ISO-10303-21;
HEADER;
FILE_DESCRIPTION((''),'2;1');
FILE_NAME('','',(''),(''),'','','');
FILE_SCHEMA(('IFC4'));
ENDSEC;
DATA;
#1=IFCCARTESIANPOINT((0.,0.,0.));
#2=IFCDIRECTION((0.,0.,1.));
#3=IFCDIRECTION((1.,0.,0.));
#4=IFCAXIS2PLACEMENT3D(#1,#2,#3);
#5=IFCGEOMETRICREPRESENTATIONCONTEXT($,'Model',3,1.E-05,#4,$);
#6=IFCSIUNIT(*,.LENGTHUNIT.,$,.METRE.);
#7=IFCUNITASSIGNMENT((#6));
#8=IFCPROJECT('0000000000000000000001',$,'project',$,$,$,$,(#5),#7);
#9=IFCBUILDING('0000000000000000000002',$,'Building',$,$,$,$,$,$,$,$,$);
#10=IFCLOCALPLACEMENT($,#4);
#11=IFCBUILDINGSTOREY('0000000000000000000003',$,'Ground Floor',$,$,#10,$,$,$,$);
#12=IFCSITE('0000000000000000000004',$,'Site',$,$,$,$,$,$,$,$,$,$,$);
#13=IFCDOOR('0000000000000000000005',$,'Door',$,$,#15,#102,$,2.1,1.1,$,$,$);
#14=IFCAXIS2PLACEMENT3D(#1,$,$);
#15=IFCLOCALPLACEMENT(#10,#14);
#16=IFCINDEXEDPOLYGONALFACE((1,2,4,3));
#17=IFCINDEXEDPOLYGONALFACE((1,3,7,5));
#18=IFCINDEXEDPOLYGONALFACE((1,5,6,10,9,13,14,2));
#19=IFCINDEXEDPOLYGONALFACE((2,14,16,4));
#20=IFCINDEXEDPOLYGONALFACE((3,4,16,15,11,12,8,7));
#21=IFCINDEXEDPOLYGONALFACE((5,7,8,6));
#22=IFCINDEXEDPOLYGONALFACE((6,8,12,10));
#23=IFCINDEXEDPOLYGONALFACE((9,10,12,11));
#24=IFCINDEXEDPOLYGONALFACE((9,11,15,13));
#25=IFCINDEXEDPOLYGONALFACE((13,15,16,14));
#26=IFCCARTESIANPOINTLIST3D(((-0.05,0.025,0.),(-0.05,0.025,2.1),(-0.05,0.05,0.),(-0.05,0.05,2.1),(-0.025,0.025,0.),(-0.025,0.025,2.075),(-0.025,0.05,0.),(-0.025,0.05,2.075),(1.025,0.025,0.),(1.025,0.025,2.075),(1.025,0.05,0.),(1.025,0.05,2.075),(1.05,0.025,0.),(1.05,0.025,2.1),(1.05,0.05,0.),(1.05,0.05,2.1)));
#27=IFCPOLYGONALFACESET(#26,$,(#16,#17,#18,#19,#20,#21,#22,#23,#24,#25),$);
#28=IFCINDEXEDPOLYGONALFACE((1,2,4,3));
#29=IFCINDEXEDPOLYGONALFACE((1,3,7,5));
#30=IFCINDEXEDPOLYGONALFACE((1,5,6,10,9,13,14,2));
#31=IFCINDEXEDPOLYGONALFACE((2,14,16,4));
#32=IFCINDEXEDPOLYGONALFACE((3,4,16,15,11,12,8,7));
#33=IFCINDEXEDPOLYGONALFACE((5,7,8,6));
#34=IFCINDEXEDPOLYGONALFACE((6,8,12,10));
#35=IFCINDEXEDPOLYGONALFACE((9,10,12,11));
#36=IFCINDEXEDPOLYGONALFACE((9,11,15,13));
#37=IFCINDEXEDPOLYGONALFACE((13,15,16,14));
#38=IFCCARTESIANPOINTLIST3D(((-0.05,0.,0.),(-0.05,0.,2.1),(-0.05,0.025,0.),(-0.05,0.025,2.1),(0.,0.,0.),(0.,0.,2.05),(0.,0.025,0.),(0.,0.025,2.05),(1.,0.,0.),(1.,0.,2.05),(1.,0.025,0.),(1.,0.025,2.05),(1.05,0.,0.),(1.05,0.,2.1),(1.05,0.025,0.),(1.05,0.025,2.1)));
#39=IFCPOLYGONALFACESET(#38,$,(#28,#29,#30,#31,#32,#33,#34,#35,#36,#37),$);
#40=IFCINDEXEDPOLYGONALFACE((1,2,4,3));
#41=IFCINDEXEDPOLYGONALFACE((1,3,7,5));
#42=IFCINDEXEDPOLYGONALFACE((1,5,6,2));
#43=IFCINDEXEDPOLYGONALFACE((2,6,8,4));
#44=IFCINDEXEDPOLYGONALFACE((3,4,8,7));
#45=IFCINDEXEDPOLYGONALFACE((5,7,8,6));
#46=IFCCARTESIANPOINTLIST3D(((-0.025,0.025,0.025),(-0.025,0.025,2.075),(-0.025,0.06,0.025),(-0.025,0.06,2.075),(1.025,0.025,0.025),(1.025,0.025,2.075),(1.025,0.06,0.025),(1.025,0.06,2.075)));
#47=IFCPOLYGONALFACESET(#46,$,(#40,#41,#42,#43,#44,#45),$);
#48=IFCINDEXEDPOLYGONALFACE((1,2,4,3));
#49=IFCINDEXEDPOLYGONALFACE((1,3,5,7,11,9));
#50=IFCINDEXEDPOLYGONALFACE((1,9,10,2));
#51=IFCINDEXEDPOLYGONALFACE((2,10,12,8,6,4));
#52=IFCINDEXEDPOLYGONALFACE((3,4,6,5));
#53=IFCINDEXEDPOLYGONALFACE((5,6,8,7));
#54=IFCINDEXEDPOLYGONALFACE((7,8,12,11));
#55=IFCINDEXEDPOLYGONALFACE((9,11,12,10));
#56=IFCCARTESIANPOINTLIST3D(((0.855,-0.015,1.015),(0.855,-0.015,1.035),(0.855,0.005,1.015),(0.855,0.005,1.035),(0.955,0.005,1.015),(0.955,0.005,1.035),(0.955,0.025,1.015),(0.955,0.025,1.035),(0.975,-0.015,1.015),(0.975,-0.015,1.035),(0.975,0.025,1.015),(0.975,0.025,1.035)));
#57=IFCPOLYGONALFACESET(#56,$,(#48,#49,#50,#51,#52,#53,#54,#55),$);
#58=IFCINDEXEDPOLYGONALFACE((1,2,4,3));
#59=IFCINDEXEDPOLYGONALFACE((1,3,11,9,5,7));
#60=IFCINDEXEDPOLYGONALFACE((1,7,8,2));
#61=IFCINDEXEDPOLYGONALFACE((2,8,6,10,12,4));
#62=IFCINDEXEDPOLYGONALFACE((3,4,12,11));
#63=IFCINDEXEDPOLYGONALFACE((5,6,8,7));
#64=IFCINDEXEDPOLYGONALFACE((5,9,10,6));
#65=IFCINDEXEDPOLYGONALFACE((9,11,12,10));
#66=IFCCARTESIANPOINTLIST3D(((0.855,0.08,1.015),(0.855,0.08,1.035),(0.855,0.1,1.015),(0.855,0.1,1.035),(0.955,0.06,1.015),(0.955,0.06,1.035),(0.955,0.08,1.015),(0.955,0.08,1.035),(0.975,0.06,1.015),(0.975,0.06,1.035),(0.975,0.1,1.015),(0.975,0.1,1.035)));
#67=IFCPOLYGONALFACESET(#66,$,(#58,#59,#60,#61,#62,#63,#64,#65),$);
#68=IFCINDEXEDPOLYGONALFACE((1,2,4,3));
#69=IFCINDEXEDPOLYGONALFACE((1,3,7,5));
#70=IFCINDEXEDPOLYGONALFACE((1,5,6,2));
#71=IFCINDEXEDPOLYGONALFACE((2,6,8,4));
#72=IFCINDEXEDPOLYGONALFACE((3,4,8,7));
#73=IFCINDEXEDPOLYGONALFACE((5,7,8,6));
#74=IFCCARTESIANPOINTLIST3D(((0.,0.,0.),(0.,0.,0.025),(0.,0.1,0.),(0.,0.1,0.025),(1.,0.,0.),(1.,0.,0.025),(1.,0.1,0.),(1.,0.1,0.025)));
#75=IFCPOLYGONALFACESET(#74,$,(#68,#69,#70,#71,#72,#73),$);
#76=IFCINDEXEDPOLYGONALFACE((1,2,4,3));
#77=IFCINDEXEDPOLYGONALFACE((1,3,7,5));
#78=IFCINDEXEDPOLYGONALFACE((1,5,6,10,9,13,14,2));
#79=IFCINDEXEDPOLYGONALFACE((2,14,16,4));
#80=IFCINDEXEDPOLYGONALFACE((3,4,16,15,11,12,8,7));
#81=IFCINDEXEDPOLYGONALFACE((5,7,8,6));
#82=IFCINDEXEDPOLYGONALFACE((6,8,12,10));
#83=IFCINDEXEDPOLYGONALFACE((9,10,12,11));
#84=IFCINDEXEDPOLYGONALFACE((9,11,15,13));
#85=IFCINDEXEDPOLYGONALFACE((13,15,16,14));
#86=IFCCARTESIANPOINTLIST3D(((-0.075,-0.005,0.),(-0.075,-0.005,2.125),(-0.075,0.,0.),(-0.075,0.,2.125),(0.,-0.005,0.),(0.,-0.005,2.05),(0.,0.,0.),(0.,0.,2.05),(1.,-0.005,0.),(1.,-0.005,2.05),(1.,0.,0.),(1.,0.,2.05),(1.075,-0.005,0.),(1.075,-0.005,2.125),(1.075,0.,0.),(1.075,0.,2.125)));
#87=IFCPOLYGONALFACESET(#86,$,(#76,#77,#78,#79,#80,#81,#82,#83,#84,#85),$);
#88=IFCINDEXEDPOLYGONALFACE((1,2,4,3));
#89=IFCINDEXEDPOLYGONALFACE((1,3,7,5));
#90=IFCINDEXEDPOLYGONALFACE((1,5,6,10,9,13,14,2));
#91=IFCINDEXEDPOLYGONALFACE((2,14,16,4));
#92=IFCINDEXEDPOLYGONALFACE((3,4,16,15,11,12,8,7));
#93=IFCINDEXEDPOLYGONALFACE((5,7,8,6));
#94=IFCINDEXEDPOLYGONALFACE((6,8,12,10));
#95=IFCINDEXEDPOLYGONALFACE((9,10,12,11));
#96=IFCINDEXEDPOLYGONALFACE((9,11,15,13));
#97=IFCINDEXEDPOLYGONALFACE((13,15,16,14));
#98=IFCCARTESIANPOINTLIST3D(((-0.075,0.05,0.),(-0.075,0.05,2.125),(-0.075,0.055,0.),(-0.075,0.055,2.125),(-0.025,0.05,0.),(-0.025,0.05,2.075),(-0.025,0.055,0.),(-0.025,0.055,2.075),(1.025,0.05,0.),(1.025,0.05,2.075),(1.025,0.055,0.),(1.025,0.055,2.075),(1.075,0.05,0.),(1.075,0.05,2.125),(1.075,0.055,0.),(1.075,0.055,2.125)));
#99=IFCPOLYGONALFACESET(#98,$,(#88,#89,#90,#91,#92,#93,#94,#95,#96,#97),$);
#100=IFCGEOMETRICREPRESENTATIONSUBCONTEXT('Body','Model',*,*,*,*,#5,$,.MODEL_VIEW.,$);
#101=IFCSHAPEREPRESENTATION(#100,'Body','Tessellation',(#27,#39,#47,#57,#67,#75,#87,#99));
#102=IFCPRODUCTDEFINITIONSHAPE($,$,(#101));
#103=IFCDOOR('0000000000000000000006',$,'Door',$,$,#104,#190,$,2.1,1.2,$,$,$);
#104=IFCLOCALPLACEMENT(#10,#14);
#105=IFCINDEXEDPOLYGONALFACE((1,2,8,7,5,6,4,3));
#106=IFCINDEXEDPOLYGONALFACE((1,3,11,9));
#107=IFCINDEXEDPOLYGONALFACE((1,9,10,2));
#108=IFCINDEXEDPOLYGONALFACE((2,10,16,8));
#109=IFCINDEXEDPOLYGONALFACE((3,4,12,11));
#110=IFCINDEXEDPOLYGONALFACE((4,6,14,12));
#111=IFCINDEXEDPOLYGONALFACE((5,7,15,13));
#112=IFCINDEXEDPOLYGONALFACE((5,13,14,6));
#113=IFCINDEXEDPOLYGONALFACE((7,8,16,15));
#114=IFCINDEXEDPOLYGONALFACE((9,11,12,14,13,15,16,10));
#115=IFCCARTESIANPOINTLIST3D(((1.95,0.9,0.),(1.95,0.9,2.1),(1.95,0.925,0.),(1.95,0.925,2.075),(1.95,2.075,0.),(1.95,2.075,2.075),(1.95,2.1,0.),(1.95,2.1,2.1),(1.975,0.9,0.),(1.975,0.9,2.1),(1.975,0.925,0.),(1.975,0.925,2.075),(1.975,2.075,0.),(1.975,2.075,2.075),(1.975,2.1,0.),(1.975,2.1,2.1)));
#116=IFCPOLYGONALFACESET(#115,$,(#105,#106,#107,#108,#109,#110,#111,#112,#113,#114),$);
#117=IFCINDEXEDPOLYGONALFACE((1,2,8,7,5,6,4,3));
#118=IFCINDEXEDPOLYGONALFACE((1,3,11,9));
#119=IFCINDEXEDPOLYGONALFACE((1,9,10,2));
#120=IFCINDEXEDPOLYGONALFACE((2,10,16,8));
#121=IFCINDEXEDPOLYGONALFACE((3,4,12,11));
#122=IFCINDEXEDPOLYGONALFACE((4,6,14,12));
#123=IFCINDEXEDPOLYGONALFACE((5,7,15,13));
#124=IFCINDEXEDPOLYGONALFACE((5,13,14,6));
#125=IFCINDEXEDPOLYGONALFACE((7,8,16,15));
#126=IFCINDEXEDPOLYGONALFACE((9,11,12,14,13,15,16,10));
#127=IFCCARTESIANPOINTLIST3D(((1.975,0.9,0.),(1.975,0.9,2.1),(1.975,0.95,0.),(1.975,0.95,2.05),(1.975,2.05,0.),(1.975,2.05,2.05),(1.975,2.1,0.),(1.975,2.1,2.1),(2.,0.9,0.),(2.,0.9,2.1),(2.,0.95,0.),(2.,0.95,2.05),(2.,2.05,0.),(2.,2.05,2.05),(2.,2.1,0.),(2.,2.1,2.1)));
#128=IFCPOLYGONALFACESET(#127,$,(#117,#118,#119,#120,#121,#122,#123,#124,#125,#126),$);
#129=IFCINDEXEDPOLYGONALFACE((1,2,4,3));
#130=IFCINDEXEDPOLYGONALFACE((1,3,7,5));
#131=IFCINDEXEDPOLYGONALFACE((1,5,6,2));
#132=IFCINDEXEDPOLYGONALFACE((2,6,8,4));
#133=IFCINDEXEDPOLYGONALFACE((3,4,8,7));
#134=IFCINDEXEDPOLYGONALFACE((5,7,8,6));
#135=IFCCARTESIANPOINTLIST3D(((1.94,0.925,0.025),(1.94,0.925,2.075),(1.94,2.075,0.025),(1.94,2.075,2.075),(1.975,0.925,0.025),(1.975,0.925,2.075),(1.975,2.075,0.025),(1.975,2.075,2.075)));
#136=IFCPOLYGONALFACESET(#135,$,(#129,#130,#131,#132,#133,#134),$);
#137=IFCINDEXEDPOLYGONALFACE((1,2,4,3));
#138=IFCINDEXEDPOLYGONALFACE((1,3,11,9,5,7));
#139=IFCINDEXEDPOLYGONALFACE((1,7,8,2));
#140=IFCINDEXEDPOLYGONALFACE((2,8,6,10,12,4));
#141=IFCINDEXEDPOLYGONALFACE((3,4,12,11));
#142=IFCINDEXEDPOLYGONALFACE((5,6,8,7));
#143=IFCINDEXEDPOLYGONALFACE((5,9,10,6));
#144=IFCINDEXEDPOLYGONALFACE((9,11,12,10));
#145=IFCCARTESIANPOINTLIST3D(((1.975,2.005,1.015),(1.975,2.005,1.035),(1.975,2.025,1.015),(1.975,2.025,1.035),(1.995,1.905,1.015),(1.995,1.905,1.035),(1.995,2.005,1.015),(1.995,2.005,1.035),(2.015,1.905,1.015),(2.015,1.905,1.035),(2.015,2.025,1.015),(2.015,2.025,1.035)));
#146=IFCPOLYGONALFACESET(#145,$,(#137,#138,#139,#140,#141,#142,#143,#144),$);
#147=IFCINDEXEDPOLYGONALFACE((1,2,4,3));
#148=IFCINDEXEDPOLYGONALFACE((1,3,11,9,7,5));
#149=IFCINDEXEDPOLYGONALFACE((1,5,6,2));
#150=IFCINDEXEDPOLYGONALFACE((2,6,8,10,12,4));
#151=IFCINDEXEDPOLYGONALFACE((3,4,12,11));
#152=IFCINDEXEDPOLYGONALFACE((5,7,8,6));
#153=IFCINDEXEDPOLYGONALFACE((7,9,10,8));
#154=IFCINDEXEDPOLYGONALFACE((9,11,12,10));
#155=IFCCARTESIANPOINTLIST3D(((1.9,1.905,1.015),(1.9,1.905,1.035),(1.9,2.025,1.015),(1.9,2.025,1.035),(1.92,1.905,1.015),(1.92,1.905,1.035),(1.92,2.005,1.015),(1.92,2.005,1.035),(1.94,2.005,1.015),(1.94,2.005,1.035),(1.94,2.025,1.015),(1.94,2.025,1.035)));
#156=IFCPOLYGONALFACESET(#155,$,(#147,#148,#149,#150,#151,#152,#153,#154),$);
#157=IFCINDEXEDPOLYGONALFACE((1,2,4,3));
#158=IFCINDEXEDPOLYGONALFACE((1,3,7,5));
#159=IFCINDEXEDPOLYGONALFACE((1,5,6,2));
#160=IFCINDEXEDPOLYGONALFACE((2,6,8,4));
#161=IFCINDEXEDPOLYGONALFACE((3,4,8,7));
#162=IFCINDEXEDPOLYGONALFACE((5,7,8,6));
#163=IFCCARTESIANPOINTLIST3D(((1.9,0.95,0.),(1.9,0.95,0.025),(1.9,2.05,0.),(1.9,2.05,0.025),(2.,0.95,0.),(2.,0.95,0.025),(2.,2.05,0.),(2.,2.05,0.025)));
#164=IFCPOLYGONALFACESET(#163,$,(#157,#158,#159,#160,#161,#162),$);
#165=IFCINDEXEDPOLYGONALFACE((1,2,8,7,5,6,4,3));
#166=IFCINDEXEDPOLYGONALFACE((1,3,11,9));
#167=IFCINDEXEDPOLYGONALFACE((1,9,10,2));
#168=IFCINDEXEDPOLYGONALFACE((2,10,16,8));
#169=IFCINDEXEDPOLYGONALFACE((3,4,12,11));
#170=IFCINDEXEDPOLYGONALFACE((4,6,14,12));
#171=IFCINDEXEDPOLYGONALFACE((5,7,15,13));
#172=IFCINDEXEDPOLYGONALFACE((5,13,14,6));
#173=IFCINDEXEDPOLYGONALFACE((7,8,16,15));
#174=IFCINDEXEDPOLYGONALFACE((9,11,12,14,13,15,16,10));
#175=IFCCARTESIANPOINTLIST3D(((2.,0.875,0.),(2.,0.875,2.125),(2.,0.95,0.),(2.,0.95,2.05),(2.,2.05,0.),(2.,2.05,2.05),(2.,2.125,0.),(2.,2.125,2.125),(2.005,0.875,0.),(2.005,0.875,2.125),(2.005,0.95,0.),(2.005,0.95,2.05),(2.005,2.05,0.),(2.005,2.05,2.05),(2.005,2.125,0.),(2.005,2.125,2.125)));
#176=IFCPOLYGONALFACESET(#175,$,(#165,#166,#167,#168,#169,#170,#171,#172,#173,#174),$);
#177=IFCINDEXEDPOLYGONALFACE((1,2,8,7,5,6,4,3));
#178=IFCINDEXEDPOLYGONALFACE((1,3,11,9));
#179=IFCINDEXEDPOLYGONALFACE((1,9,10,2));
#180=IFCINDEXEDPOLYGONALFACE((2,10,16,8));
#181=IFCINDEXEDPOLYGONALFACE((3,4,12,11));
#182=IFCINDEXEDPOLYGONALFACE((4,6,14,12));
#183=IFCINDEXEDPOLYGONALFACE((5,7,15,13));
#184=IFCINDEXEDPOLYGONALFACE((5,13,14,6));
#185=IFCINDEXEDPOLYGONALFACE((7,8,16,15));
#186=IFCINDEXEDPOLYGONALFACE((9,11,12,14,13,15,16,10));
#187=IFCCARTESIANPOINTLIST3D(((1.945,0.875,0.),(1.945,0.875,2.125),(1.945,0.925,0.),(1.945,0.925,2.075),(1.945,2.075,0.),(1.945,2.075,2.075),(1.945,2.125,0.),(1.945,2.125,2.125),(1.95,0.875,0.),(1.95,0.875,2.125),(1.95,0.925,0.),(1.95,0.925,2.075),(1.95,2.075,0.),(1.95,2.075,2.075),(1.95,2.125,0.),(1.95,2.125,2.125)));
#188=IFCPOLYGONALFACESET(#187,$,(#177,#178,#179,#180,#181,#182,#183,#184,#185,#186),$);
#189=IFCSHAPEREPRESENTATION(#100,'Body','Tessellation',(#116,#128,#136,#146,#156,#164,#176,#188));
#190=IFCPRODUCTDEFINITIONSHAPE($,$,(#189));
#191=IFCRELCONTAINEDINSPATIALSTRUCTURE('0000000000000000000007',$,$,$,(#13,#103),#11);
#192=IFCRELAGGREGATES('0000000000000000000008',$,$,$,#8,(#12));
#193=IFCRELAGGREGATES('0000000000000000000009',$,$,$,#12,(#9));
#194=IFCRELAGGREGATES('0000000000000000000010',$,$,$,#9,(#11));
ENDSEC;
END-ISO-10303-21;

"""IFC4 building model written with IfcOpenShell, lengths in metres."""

from ifc_helpers import new_model, si_unit, frame, origin_with_axes, place, context, subcontext, project, spatial, line, indexed_curve, outline, extrude, element, save


model = new_model("IFC4")

# Units and contexts
model_context = context("Model", 3, precision=1e-05, world=origin_with_axes())
body_context = subcontext(model_context, "Body", "Model", "MODEL_VIEW")
ifc_project = project(units=[si_unit("LENGTHUNIT", "METRE")], contexts=[model_context])

# Site, building, storey
site = spatial("IfcSite", under=ifc_project, Name="Site")
building = spatial("IfcBuilding", under=site, Name="Building")
storey_placement = place(None, origin_with_axes())
storey = spatial("IfcBuildingStorey", under=building, at=storey_placement, Name="Ground Floor")

# Doors
door_1_placement = place(storey_placement, frame((-0.05, 0.0, 0.0), z_axis=(0.0, 0.0, 1.0), x_axis=(1.0, 0.0, 0.0)))
element("IfcDoor", 1, at=door_1_placement, inside=storey, Name="Door", OverallHeight=2.1, OverallWidth=1.1, context=body_context, shape_type="SweptSolid", body=[
    extrude(outline(indexed_curve([(0.0, 0.0), (0.0, 2.1), (1.1, 2.1), (1.1, 0.0), (1.075, 0.0), (1.075, 2.075), (0.025, 2.075), (0.025, 0.0)], segments=[line(1, 2, 3, 4, 5, 6, 7, 8, 1)])), frame((0.0, 0.025, 0.0), z_axis=(0.0, -1.0, 0.0), x_axis=(1.0, 0.0, 0.0)), (0.0, 0.0, -1.0), 0.025),
    extrude(outline(indexed_curve([(0.0, 0.0), (0.0, 2.1), (1.1, 2.1), (1.1, 0.0), (1.05, 0.0), (1.05, 2.05), (0.05, 2.05), (0.05, 0.0)], segments=[line(1, 2, 3, 4, 5, 6, 7, 8, 1)])), frame((0.0, 0.0, 0.0), z_axis=(0.0, -1.0, 0.0), x_axis=(1.0, 0.0, 0.0)), (0.0, 0.0, -1.0), 0.025),
    extrude(outline(indexed_curve([(0.0, 0.0), (1.05, 0.0), (1.05, 0.035), (0.0, 0.035)], segments=[line(1, 2, 3, 4, 1)])), frame((0.025, 0.025, 0.025), z_axis=(0.0, 0.0, 1.0), x_axis=(1.0, 0.0, 0.0)), (0.0, 0.0, 1.0), 2.05),
    extrude(outline(indexed_curve([(0.0, 0.0), (0.0, -0.04), (-0.12, -0.04), (-0.12, -0.02), (-0.02, -0.02), (-0.02, 0.0)], segments=[line(1, 2, 3, 4, 5, 6, 1)])), frame((1.025, 0.025, 1.015), z_axis=(0.0, 0.0, 1.0), x_axis=(1.0, 0.0, 0.0)), (0.0, 0.0, 1.0), 0.02),
    extrude(outline(indexed_curve([(0.0, 0.0), (0.0, 0.04), (-0.12, 0.04), (-0.12, 0.02), (-0.02, 0.02), (-0.02, 0.0)], segments=[line(1, 2, 3, 4, 5, 6, 1)])), frame((1.025, 0.06, 1.015), z_axis=(0.0, 0.0, 1.0), x_axis=(1.0, 0.0, 0.0)), (0.0, 0.0, 1.0), 0.02),
    extrude(outline(indexed_curve([(0.0, 0.0), (1.0, 0.0), (1.0, 0.1), (0.0, 0.1)], segments=[line(1, 2, 3, 4, 1)])), frame((0.05, 0.0, 0.0), z_axis=(0.0, 0.0, 1.0), x_axis=(1.0, 0.0, 0.0)), (0.0, 0.0, 1.0), 0.025),
    extrude(outline(indexed_curve([(0.0, 0.0), (0.0, 2.125), (1.15, 2.125), (1.15, 0.0), (1.075, 0.0), (1.075, 2.05), (0.075, 2.05), (0.075, 0.0)], segments=[line(1, 2, 3, 4, 5, 6, 7, 8, 1)])), frame((-0.025, -0.005, 0.0), z_axis=(0.0, -1.0, 0.0), x_axis=(1.0, 0.0, 0.0)), (0.0, 0.0, -1.0), 0.005),
    extrude(outline(indexed_curve([(0.0, 0.0), (0.0, 2.125), (1.15, 2.125), (1.15, 0.0), (1.1, 0.0), (1.1, 2.075), (0.05, 2.075), (0.05, 0.0)], segments=[line(1, 2, 3, 4, 5, 6, 7, 8, 1)])), frame((-0.025, 0.05, 0.0), z_axis=(0.0, -1.0, 0.0), x_axis=(1.0, 0.0, 0.0)), (0.0, 0.0, -1.0), 0.005),
])
door_2_placement = place(storey_placement, frame((2.0, 0.9, 0.0), z_axis=(0.0, 0.0, 1.0), x_axis=(0.0, 1.0, 0.0)))
element("IfcDoor", 2, at=door_2_placement, inside=storey, Name="Door", OverallHeight=2.1, OverallWidth=1.2, context=body_context, shape_type="SweptSolid", body=[
    extrude(outline(indexed_curve([(0.0, 0.0), (0.0, 2.1), (1.2, 2.1), (1.2, 0.0), (1.175, 0.0), (1.175, 2.075), (0.025, 2.075), (0.025, 0.0)], segments=[line(1, 2, 3, 4, 5, 6, 7, 8, 1)])), frame((0.0, 0.025, 0.0), z_axis=(0.0, -1.0, 0.0), x_axis=(1.0, 0.0, 0.0)), (0.0, 0.0, -1.0), 0.025),
    extrude(outline(indexed_curve([(0.0, 0.0), (0.0, 2.1), (1.2, 2.1), (1.2, 0.0), (1.15, 0.0), (1.15, 2.05), (0.05, 2.05), (0.05, 0.0)], segments=[line(1, 2, 3, 4, 5, 6, 7, 8, 1)])), frame((0.0, 0.0, 0.0), z_axis=(0.0, -1.0, 0.0), x_axis=(1.0, 0.0, 0.0)), (0.0, 0.0, -1.0), 0.025),
    extrude(outline(indexed_curve([(0.0, 0.0), (1.15, 0.0), (1.15, 0.035), (0.0, 0.035)], segments=[line(1, 2, 3, 4, 1)])), frame((0.025, 0.025, 0.025), z_axis=(0.0, 0.0, 1.0), x_axis=(1.0, 0.0, 0.0)), (0.0, 0.0, 1.0), 2.05),
    extrude(outline(indexed_curve([(0.0, 0.0), (0.0, -0.04), (-0.12, -0.04), (-0.12, -0.02), (-0.02, -0.02), (-0.02, 0.0)], segments=[line(1, 2, 3, 4, 5, 6, 1)])), frame((1.125, 0.025, 1.015), z_axis=(0.0, 0.0, 1.0), x_axis=(1.0, 0.0, 0.0)), (0.0, 0.0, 1.0), 0.02),
    extrude(outline(indexed_curve([(0.0, 0.0), (0.0, 0.04), (-0.12, 0.04), (-0.12, 0.02), (-0.02, 0.02), (-0.02, 0.0)], segments=[line(1, 2, 3, 4, 5, 6, 1)])), frame((1.125, 0.06, 1.015), z_axis=(0.0, 0.0, 1.0), x_axis=(1.0, 0.0, 0.0)), (0.0, 0.0, 1.0), 0.02),
    extrude(outline(indexed_curve([(0.0, 0.0), (1.1, 0.0), (1.1, 0.1), (0.0, 0.1)], segments=[line(1, 2, 3, 4, 1)])), frame((0.05, 0.0, 0.0), z_axis=(0.0, 0.0, 1.0), x_axis=(1.0, 0.0, 0.0)), (0.0, 0.0, 1.0), 0.025),
    extrude(outline(indexed_curve([(0.0, 0.0), (0.0, 2.125), (1.25, 2.125), (1.25, 0.0), (1.175, 0.0), (1.175, 2.05), (0.075, 2.05), (0.075, 0.0)], segments=[line(1, 2, 3, 4, 5, 6, 7, 8, 1)])), frame((-0.025, -0.005, 0.0), z_axis=(0.0, -1.0, 0.0), x_axis=(1.0, 0.0, 0.0)), (0.0, 0.0, -1.0), 0.005),
    extrude(outline(indexed_curve([(0.0, 0.0), (0.0, 2.125), (1.25, 2.125), (1.25, 0.0), (1.2, 0.0), (1.2, 2.075), (0.05, 2.075), (0.05, 0.0)], segments=[line(1, 2, 3, 4, 5, 6, 7, 8, 1)])), frame((-0.025, 0.05, 0.0), z_axis=(0.0, -1.0, 0.0), x_axis=(1.0, 0.0, 0.0)), (0.0, 0.0, -1.0), 0.005),
])

save(model, "model.ifc")
